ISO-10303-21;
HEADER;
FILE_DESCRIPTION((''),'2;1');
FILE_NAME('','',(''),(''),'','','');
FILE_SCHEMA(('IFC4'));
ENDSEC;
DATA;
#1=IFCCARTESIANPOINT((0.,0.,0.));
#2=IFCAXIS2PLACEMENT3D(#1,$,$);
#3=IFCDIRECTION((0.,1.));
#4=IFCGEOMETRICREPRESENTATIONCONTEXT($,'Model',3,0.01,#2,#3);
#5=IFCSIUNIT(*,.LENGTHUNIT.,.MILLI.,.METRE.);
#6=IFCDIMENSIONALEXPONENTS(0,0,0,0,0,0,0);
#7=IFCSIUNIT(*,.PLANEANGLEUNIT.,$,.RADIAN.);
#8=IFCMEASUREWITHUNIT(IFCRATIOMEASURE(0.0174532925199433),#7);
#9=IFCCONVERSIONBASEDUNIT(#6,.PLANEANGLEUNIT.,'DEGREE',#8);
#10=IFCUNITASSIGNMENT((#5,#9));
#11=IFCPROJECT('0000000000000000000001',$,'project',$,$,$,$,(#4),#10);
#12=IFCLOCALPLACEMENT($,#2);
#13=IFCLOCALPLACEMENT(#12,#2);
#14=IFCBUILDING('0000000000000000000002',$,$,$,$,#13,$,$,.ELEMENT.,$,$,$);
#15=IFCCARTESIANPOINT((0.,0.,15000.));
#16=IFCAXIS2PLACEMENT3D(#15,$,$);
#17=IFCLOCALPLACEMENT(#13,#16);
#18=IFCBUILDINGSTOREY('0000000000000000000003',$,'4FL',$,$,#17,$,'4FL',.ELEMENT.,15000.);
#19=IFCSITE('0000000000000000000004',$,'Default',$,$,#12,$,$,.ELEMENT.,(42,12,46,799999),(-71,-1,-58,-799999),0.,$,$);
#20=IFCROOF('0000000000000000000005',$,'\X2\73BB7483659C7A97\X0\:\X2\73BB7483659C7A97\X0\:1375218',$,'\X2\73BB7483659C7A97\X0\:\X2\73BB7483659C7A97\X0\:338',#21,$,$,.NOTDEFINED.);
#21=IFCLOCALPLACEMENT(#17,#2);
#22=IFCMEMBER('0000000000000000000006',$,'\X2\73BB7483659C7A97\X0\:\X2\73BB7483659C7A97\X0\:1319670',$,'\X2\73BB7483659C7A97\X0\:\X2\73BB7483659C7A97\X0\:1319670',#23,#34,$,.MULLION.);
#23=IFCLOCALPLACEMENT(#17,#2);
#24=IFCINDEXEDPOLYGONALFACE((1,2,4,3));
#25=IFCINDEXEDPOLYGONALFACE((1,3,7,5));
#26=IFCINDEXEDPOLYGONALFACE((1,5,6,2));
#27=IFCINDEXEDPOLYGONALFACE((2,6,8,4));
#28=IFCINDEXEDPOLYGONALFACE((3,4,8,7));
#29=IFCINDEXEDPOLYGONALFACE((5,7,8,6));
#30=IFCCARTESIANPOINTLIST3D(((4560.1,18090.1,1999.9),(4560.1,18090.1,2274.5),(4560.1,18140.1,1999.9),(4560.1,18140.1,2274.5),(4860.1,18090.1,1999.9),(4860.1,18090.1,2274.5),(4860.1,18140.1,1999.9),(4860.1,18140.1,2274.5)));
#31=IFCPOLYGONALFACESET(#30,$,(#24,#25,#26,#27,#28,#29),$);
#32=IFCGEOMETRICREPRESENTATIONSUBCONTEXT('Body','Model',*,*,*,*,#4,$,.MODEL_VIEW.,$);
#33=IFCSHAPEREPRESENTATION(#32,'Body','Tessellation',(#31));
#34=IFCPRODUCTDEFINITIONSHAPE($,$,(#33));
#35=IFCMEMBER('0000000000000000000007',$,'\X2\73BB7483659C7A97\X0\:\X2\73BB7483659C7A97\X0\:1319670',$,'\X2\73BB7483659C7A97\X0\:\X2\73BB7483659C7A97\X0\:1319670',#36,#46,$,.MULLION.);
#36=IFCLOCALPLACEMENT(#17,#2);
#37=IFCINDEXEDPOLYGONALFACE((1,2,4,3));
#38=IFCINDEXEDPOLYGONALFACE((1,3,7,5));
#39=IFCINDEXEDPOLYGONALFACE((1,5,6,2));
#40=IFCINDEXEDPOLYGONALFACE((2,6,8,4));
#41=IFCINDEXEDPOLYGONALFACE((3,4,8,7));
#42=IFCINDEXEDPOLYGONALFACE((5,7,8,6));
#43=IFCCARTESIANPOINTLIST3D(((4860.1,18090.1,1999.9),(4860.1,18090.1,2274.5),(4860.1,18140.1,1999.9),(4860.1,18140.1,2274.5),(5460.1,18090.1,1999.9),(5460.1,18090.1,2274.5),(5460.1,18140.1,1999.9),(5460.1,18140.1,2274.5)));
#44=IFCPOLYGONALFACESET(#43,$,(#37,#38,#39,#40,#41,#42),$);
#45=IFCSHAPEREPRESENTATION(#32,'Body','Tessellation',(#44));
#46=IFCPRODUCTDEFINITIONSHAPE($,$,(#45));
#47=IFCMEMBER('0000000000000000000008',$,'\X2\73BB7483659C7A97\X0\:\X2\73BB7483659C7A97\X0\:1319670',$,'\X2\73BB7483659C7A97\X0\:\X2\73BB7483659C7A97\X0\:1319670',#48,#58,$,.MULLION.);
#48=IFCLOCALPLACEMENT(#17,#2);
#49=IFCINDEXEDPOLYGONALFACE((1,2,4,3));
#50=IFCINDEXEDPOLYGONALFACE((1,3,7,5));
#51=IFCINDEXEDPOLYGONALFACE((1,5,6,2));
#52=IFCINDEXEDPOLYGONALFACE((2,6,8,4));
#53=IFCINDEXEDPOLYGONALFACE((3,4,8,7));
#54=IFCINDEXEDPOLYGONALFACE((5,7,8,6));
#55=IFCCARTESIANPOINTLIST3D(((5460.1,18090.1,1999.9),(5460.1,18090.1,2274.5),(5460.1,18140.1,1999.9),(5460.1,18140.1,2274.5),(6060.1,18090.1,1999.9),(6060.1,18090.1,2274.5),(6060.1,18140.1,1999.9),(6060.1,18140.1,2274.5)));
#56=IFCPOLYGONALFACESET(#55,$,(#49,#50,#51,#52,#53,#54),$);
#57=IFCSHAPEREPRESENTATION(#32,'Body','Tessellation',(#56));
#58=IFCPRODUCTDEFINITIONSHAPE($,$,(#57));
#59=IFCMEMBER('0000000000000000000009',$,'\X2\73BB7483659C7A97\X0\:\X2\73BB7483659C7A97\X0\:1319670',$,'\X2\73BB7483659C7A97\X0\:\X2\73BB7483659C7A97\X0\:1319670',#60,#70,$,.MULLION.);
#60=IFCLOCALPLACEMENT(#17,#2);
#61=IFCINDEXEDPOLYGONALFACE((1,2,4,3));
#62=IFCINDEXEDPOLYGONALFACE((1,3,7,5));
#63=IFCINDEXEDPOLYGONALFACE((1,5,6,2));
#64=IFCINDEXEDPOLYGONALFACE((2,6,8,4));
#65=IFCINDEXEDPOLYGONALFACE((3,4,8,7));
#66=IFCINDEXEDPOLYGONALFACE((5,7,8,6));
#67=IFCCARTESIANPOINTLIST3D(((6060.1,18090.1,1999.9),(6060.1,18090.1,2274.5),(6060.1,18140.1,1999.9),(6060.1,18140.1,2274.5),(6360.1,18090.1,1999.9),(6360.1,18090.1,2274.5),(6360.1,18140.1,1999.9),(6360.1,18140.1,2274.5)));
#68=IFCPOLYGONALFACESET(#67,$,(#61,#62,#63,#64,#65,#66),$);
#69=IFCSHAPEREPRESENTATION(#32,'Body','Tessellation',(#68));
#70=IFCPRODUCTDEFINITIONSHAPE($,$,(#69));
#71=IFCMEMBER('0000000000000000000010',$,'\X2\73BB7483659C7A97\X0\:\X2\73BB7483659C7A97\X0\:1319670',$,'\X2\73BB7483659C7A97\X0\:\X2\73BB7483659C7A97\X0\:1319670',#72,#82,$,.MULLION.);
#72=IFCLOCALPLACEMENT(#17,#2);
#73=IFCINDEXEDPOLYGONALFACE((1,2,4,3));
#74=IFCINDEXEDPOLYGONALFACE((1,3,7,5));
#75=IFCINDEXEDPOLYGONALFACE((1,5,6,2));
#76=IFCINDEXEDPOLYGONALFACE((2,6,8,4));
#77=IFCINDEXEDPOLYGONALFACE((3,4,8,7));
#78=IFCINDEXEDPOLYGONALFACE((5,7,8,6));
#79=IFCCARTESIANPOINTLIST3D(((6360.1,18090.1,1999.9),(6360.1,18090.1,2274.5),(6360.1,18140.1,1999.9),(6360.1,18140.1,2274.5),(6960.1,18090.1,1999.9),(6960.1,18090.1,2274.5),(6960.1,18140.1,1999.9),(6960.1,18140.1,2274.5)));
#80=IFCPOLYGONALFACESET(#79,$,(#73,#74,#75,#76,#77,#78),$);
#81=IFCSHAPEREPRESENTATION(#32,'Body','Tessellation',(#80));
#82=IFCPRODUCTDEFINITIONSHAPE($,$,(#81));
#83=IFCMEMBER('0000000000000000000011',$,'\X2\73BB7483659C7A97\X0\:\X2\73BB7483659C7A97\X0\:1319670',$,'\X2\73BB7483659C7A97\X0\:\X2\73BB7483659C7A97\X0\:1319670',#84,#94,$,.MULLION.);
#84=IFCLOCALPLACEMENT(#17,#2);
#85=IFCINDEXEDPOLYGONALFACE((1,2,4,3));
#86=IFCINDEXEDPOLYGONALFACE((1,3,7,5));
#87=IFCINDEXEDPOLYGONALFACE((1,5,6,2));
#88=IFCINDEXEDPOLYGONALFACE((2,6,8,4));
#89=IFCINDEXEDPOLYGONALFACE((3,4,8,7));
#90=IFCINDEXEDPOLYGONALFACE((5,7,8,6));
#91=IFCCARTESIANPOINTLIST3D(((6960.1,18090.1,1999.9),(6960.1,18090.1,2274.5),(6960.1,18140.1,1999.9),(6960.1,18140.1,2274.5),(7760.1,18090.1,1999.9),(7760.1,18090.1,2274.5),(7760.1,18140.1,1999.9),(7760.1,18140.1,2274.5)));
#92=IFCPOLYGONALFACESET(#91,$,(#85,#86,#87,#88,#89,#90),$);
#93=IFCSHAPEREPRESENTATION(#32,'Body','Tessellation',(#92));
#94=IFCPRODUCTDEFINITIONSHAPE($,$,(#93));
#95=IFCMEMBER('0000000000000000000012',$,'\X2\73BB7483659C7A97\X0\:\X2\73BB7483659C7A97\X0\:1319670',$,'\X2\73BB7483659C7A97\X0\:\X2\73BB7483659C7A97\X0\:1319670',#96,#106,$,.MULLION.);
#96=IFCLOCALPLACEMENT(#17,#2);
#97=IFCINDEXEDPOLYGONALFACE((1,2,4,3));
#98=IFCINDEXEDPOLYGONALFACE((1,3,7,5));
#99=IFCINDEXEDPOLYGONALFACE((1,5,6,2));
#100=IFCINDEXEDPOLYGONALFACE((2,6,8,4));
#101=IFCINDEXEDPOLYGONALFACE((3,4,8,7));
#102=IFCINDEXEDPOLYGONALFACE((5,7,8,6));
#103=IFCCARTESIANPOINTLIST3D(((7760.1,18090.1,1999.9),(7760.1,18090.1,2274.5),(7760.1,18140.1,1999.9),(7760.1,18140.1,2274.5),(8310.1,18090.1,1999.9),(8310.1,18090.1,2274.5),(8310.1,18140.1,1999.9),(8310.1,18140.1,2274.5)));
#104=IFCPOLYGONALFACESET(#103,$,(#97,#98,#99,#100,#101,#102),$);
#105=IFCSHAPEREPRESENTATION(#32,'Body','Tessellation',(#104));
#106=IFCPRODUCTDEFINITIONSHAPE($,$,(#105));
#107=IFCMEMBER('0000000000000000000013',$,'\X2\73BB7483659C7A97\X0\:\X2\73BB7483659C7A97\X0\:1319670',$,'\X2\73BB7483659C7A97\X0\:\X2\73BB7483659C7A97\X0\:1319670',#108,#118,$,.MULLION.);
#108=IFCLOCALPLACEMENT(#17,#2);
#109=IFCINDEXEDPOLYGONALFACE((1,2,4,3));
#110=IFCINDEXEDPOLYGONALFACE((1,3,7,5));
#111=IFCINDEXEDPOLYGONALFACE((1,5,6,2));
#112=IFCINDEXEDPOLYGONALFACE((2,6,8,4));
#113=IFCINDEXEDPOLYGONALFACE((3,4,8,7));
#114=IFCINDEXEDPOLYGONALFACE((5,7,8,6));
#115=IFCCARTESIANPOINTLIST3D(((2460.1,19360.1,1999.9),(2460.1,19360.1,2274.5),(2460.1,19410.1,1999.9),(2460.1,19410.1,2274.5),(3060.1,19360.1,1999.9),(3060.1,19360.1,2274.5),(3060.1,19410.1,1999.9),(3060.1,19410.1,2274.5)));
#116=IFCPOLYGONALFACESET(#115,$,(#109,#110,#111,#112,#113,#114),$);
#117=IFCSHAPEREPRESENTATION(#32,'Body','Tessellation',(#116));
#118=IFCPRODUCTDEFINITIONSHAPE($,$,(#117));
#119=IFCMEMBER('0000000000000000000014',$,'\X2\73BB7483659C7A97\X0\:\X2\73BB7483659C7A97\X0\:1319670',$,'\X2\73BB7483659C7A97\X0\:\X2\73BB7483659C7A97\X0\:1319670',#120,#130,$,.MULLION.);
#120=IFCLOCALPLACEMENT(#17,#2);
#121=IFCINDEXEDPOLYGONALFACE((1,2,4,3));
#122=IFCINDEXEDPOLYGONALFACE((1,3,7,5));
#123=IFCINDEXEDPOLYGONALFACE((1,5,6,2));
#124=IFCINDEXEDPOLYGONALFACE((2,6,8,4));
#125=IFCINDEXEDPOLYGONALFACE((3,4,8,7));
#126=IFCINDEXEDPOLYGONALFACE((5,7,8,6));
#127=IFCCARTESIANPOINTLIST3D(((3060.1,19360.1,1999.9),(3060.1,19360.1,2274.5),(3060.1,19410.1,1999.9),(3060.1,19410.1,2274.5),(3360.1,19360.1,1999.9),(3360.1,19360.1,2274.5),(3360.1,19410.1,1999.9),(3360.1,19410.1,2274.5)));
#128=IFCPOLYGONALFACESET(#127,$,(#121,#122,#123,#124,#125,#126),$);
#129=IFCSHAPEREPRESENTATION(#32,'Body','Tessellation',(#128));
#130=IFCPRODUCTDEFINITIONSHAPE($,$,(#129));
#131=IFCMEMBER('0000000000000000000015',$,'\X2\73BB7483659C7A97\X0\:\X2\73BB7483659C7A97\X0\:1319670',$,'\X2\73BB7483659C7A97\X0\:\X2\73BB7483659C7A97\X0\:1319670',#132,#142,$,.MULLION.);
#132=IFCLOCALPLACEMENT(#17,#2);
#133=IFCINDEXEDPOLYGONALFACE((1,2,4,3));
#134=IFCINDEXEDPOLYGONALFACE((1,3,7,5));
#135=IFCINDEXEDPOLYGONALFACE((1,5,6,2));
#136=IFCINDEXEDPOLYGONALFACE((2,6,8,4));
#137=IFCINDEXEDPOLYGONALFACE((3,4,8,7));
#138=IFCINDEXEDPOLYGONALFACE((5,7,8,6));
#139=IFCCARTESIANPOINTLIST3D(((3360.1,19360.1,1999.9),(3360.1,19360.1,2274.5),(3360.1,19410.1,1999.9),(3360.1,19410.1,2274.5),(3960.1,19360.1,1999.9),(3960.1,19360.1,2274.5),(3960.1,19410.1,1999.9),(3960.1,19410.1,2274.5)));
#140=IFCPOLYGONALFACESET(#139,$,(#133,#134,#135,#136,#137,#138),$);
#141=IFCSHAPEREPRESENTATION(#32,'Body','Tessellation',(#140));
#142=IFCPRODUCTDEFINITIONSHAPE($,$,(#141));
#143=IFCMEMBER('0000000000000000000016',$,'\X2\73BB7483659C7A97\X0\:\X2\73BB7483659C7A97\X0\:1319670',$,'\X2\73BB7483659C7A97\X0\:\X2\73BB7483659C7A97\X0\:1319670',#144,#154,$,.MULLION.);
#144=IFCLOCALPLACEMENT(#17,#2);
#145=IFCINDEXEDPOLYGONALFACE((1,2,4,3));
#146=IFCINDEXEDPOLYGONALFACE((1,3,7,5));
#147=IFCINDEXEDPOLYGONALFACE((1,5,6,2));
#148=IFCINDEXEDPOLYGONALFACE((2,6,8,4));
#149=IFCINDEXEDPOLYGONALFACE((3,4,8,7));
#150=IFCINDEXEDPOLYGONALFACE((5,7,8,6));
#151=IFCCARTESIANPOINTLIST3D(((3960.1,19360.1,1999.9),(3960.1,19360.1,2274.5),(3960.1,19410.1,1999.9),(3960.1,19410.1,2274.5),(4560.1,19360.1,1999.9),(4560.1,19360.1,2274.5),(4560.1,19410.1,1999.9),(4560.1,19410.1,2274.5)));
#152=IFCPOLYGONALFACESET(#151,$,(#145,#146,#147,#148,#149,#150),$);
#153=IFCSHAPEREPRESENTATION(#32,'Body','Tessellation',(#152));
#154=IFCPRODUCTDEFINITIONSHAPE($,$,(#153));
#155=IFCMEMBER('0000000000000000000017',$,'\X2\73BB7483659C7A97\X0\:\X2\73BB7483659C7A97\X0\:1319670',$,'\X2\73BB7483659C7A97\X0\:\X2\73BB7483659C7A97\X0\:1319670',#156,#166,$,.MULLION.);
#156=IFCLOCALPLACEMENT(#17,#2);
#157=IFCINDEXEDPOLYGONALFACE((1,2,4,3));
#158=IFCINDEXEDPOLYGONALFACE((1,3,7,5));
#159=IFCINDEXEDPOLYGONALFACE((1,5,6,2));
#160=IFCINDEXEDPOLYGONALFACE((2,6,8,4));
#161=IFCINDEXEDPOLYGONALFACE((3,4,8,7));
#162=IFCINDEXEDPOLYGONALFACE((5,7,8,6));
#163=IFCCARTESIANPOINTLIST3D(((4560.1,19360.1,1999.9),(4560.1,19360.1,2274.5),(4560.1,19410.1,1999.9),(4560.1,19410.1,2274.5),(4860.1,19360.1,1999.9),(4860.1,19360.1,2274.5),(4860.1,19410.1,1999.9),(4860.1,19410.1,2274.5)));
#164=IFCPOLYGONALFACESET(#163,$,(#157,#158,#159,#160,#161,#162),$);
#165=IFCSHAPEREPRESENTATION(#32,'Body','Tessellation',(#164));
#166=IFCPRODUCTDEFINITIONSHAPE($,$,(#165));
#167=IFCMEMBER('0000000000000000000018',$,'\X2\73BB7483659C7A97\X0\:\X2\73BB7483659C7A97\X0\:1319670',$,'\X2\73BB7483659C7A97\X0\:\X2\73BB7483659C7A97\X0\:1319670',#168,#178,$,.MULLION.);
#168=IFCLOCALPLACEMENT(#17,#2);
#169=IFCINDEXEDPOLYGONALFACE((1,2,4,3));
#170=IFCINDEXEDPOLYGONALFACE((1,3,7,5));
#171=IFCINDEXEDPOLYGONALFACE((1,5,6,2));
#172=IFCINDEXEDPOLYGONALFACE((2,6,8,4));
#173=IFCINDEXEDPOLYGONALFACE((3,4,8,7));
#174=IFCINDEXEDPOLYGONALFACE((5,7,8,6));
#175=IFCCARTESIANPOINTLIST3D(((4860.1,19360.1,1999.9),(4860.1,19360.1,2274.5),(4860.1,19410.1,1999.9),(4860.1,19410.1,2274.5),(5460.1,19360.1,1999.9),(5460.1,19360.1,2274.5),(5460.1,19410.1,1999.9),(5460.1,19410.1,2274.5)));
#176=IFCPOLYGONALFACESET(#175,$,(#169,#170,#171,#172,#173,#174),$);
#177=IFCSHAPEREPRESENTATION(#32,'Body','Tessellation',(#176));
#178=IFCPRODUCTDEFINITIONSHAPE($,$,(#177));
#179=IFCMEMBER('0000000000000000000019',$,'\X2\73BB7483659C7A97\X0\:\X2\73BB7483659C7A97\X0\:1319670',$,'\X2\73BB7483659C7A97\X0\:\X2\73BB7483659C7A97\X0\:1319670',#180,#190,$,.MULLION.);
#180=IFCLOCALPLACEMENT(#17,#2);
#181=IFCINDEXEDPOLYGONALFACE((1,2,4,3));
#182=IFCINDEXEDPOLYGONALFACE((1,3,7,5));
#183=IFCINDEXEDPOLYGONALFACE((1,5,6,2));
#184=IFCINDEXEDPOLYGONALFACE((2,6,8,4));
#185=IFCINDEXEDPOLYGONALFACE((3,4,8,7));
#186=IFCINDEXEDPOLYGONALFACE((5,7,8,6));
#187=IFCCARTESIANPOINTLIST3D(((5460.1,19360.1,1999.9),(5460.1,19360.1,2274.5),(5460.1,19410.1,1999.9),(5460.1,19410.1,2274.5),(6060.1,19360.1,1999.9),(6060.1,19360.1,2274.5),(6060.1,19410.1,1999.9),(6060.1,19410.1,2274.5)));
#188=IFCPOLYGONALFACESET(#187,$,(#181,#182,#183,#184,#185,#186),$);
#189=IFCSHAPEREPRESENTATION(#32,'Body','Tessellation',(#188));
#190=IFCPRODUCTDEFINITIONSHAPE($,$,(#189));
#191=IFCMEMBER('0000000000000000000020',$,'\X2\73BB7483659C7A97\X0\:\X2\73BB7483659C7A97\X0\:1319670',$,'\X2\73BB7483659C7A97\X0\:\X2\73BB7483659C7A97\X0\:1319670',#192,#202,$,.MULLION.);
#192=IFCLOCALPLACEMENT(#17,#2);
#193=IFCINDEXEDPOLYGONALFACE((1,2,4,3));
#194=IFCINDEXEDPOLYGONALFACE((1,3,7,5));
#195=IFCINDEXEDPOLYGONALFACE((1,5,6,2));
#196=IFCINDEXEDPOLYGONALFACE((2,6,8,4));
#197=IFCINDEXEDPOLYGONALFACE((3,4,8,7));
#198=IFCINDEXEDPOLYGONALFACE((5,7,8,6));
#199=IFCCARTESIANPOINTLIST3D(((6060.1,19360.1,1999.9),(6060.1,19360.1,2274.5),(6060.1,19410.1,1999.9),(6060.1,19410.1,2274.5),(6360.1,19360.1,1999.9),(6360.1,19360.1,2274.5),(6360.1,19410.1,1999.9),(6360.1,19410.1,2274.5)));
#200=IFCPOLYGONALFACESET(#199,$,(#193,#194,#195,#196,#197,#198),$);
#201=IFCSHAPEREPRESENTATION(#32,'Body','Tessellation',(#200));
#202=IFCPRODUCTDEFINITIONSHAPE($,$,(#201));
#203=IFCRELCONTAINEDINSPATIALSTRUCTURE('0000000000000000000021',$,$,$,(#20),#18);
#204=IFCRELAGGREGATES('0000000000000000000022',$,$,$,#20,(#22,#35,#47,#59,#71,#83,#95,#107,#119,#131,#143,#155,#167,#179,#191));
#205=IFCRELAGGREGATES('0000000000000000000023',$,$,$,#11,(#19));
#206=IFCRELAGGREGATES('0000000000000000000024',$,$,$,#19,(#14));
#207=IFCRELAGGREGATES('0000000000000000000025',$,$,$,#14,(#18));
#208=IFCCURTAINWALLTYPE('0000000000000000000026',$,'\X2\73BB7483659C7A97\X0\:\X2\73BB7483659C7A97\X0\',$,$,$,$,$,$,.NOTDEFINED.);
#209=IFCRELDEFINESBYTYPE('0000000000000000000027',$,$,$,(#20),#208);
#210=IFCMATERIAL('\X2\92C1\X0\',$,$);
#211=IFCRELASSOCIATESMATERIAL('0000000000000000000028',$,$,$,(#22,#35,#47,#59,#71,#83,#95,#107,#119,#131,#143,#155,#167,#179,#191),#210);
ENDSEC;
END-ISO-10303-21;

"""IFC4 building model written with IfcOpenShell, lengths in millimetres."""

from ifc_helpers import new_model, entity, si_unit, converted_unit, direction, frame, frame_2d, origin, place, context, subcontext, project, spatial, rectangle, extrude, material, type_object, element, aggregate, save


model = new_model("IFC4")

# Units and contexts
model_context = context("Model", 3, precision=0.01, world=origin(), true_north=direction((0.0, 1.0)))
body_context = subcontext(model_context, "Body", "Model", "MODEL_VIEW")
ifc_project = project(units=[si_unit("LENGTHUNIT", "METRE", prefix="MILLI"), converted_unit("PLANEANGLEUNIT", "DEGREE", entity("IfcRatioMeasure", 0.0174532925199433), si_unit("PLANEANGLEUNIT", "RADIAN"), dimensions=[0, 0, 0, 0, 0, 0, 0])], contexts=[model_context])

# Site, building, storey
site_placement = place(None, origin())
site = spatial("IfcSite", under=ifc_project, at=site_placement, Name="Default", CompositionType="ELEMENT", RefLatitude=(42, 12, 46, 799999), RefLongitude=(-71, -1, -58, -799999), RefElevation=0.0)
building_placement = place(site_placement, origin())
building = spatial("IfcBuilding", under=site, at=building_placement, CompositionType="ELEMENT")
storey_placement = place(building_placement, frame((0.0, 0.0, 15000.0)))
storey = spatial("IfcBuildingStorey", under=building, at=storey_placement, Name="4FL", LongName="4FL", CompositionType="ELEMENT", Elevation=15000.0)

# Roof, members
curtain_wall_type = type_object("IfcCurtainWallType", Name="玻璃斜窗:玻璃斜窗", PredefinedType="NOTDEFINED")
roof_placement = place(storey_placement, frame((0.0, 0.0, -15000.0)))
roof = element("IfcRoof", 1, at=roof_placement, inside=storey, type_object=curtain_wall_type, Name="玻璃斜窗:玻璃斜窗:1375218", ObjectType="玻璃斜窗:玻璃斜窗:338", PredefinedType="NOTDEFINED")
ifc_material_1 = material(Name="鋁")
member_1_placement = place(roof_placement, frame((0.0, 0.0, 15000.0)))
member_1 = element("IfcMember", 2, at=member_1_placement, material=ifc_material_1, Name="玻璃斜窗:玻璃斜窗:1319670", ObjectType="玻璃斜窗:玻璃斜窗:1319670", PredefinedType="MULLION", context=body_context, shape_type="SweptSolid", body=[
    extrude(rectangle(XDim=274.5, YDim=50.0, at=frame_2d((0.0, 0.0), x_axis=(1.0, 0.0))), frame((4860.1, 18115.1, 2137.2), z_axis=(-1.0, 0.0, 0.0), x_axis=(0.0, 0.0, -1.0)), (0.0, 0.0, 1.0), 300.0),
])
member_2_placement = place(roof_placement, frame((0.0, 0.0, 15000.0)))
member_2 = element("IfcMember", 3, at=member_2_placement, material=ifc_material_1, Name="玻璃斜窗:玻璃斜窗:1319670", ObjectType="玻璃斜窗:玻璃斜窗:1319670", PredefinedType="MULLION", context=body_context, shape_type="SweptSolid", body=[
    extrude(rectangle(XDim=274.5, YDim=50.0, at=frame_2d((0.0, 0.0), x_axis=(1.0, 0.0))), frame((5460.1, 18115.1, 2137.2), z_axis=(-1.0, 0.0, 0.0), x_axis=(0.0, 0.0, -1.0)), (0.0, 0.0, 1.0), 600.0),
])
member_3_placement = place(roof_placement, frame((0.0, 0.0, 15000.0)))
member_3 = element("IfcMember", 4, at=member_3_placement, material=ifc_material_1, Name="玻璃斜窗:玻璃斜窗:1319670", ObjectType="玻璃斜窗:玻璃斜窗:1319670", PredefinedType="MULLION", context=body_context, shape_type="SweptSolid", body=[
    extrude(rectangle(XDim=274.5, YDim=50.0, at=frame_2d((0.0, 0.0), x_axis=(1.0, 0.0))), frame((6060.1, 18115.1, 2137.2), z_axis=(-1.0, 0.0, 0.0), x_axis=(0.0, 0.0, -1.0)), (0.0, 0.0, 1.0), 600.0),
])
member_4_placement = place(roof_placement, frame((0.0, 0.0, 15000.0)))
member_4 = element("IfcMember", 5, at=member_4_placement, material=ifc_material_1, Name="玻璃斜窗:玻璃斜窗:1319670", ObjectType="玻璃斜窗:玻璃斜窗:1319670", PredefinedType="MULLION", context=body_context, shape_type="SweptSolid", body=[
    extrude(rectangle(XDim=274.5, YDim=50.0, at=frame_2d((0.0, 0.0), x_axis=(1.0, 0.0))), frame((6360.1, 18115.1, 2137.2), z_axis=(-1.0, 0.0, 0.0), x_axis=(0.0, 0.0, -1.0)), (0.0, 0.0, 1.0), 300.0),
])
member_5_placement = place(roof_placement, frame((0.0, 0.0, 15000.0)))
member_5 = element("IfcMember", 6, at=member_5_placement, material=ifc_material_1, Name="玻璃斜窗:玻璃斜窗:1319670", ObjectType="玻璃斜窗:玻璃斜窗:1319670", PredefinedType="MULLION", context=body_context, shape_type="SweptSolid", body=[
    extrude(rectangle(XDim=274.5, YDim=50.0, at=frame_2d((0.0, 0.0), x_axis=(1.0, 0.0))), frame((6960.1, 18115.1, 2137.2), z_axis=(-1.0, 0.0, 0.0), x_axis=(0.0, 0.0, -1.0)), (0.0, 0.0, 1.0), 600.0),
])
member_6_placement = place(roof_placement, frame((0.0, 0.0, 15000.0)))
member_6 = element("IfcMember", 7, at=member_6_placement, material=ifc_material_1, Name="玻璃斜窗:玻璃斜窗:1319670", ObjectType="玻璃斜窗:玻璃斜窗:1319670", PredefinedType="MULLION", context=body_context, shape_type="SweptSolid", body=[
    extrude(rectangle(XDim=274.5, YDim=50.0, at=frame_2d((0.0, 0.0), x_axis=(1.0, 0.0))), frame((7760.1, 18115.1, 2137.2), z_axis=(-1.0, 0.0, 0.0), x_axis=(0.0, 0.0, -1.0)), (0.0, 0.0, 1.0), 800.0),
])
member_7_placement = place(roof_placement, frame((0.0, 0.0, 15000.0)))
member_7 = element("IfcMember", 8, at=member_7_placement, material=ifc_material_1, Name="玻璃斜窗:玻璃斜窗:1319670", ObjectType="玻璃斜窗:玻璃斜窗:1319670", PredefinedType="MULLION", context=body_context, shape_type="SweptSolid", body=[
    extrude(rectangle(XDim=274.5, YDim=50.0, at=frame_2d((0.0, 0.0), x_axis=(1.0, 0.0))), frame((8310.1, 18115.1, 2137.2), z_axis=(-1.0, 0.0, 0.0), x_axis=(0.0, 0.0, -1.0)), (0.0, 0.0, 1.0), 550.0),
])
member_8_placement = place(roof_placement, frame((0.0, 0.0, 15000.0)))
member_8 = element("IfcMember", 9, at=member_8_placement, material=ifc_material_1, Name="玻璃斜窗:玻璃斜窗:1319670", ObjectType="玻璃斜窗:玻璃斜窗:1319670", PredefinedType="MULLION", context=body_context, shape_type="SweptSolid", body=[
    extrude(rectangle(XDim=274.5, YDim=50.0, at=frame_2d((0.0, 0.0), x_axis=(1.0, 0.0))), frame((2460.1, 19385.1, 2137.2), z_axis=(1.0, 0.0, 0.0), x_axis=(0.0, 0.0, -1.0)), (0.0, 0.0, 1.0), 600.0),
])
member_9_placement = place(roof_placement, frame((0.0, 0.0, 15000.0)))
member_9 = element("IfcMember", 10, at=member_9_placement, material=ifc_material_1, Name="玻璃斜窗:玻璃斜窗:1319670", ObjectType="玻璃斜窗:玻璃斜窗:1319670", PredefinedType="MULLION", context=body_context, shape_type="SweptSolid", body=[
    extrude(rectangle(XDim=274.5, YDim=50.0, at=frame_2d((0.0, 0.0), x_axis=(1.0, 0.0))), frame((3060.1, 19385.1, 2137.2), z_axis=(1.0, 0.0, 0.0), x_axis=(0.0, 0.0, -1.0)), (0.0, 0.0, 1.0), 300.0),
])
member_10_placement = place(roof_placement, frame((0.0, 0.0, 15000.0)))
member_10 = element("IfcMember", 11, at=member_10_placement, material=ifc_material_1, Name="玻璃斜窗:玻璃斜窗:1319670", ObjectType="玻璃斜窗:玻璃斜窗:1319670", PredefinedType="MULLION", context=body_context, shape_type="SweptSolid", body=[
    extrude(rectangle(XDim=274.5, YDim=50.0, at=frame_2d((0.0, 0.0), x_axis=(1.0, 0.0))), frame((3360.1, 19385.1, 2137.2), z_axis=(1.0, 0.0, 0.0), x_axis=(0.0, 0.0, -1.0)), (0.0, 0.0, 1.0), 600.0),
])
member_11_placement = place(roof_placement, frame((0.0, 0.0, 15000.0)))
member_11 = element("IfcMember", 12, at=member_11_placement, material=ifc_material_1, Name="玻璃斜窗:玻璃斜窗:1319670", ObjectType="玻璃斜窗:玻璃斜窗:1319670", PredefinedType="MULLION", context=body_context, shape_type="SweptSolid", body=[
    extrude(rectangle(XDim=274.5, YDim=50.0, at=frame_2d((0.0, 0.0), x_axis=(1.0, 0.0))), frame((3960.1, 19385.1, 2137.2), z_axis=(1.0, 0.0, 0.0), x_axis=(0.0, 0.0, -1.0)), (0.0, 0.0, 1.0), 600.0),
])
member_12_placement = place(roof_placement, frame((0.0, 0.0, 15000.0)))
member_12 = element("IfcMember", 13, at=member_12_placement, material=ifc_material_1, Name="玻璃斜窗:玻璃斜窗:1319670", ObjectType="玻璃斜窗:玻璃斜窗:1319670", PredefinedType="MULLION", context=body_context, shape_type="SweptSolid", body=[
    extrude(rectangle(XDim=274.5, YDim=50.0, at=frame_2d((0.0, 0.0), x_axis=(1.0, 0.0))), frame((4560.1, 19385.1, 2137.2), z_axis=(1.0, 0.0, 0.0), x_axis=(0.0, 0.0, -1.0)), (0.0, 0.0, 1.0), 300.0),
])
member_13_placement = place(roof_placement, frame((0.0, 0.0, 15000.0)))
member_13 = element("IfcMember", 14, at=member_13_placement, material=ifc_material_1, Name="玻璃斜窗:玻璃斜窗:1319670", ObjectType="玻璃斜窗:玻璃斜窗:1319670", PredefinedType="MULLION", context=body_context, shape_type="SweptSolid", body=[
    extrude(rectangle(XDim=274.5, YDim=50.0, at=frame_2d((0.0, 0.0), x_axis=(1.0, 0.0))), frame((4860.1, 19385.1, 2137.2), z_axis=(1.0, 0.0, 0.0), x_axis=(0.0, 0.0, -1.0)), (0.0, 0.0, 1.0), 600.0),
])
member_14_placement = place(roof_placement, frame((0.0, 0.0, 15000.0)))
member_14 = element("IfcMember", 15, at=member_14_placement, material=ifc_material_1, Name="玻璃斜窗:玻璃斜窗:1319670", ObjectType="玻璃斜窗:玻璃斜窗:1319670", PredefinedType="MULLION", context=body_context, shape_type="SweptSolid", body=[
    extrude(rectangle(XDim=274.5, YDim=50.0, at=frame_2d((0.0, 0.0), x_axis=(1.0, 0.0))), frame((5460.1, 19385.1, 2137.2), z_axis=(1.0, 0.0, 0.0), x_axis=(0.0, 0.0, -1.0)), (0.0, 0.0, 1.0), 600.0),
])
member_15_placement = place(roof_placement, frame((0.0, 0.0, 15000.0)))
member_15 = element("IfcMember", 16, at=member_15_placement, material=ifc_material_1, Name="玻璃斜窗:玻璃斜窗:1319670", ObjectType="玻璃斜窗:玻璃斜窗:1319670", PredefinedType="MULLION", context=body_context, shape_type="SweptSolid", body=[
    extrude(rectangle(XDim=274.5, YDim=50.0, at=frame_2d((0.0, 0.0), x_axis=(1.0, 0.0))), frame((6060.1, 19385.1, 2137.2), z_axis=(1.0, 0.0, 0.0), x_axis=(0.0, 0.0, -1.0)), (0.0, 0.0, 1.0), 300.0),
])
aggregate(roof, [member_1, member_2, member_3, member_4, member_5, member_6, member_7, member_8, member_9, member_10, member_11, member_12, member_13, member_14, member_15])

save(model, "model.ifc")
